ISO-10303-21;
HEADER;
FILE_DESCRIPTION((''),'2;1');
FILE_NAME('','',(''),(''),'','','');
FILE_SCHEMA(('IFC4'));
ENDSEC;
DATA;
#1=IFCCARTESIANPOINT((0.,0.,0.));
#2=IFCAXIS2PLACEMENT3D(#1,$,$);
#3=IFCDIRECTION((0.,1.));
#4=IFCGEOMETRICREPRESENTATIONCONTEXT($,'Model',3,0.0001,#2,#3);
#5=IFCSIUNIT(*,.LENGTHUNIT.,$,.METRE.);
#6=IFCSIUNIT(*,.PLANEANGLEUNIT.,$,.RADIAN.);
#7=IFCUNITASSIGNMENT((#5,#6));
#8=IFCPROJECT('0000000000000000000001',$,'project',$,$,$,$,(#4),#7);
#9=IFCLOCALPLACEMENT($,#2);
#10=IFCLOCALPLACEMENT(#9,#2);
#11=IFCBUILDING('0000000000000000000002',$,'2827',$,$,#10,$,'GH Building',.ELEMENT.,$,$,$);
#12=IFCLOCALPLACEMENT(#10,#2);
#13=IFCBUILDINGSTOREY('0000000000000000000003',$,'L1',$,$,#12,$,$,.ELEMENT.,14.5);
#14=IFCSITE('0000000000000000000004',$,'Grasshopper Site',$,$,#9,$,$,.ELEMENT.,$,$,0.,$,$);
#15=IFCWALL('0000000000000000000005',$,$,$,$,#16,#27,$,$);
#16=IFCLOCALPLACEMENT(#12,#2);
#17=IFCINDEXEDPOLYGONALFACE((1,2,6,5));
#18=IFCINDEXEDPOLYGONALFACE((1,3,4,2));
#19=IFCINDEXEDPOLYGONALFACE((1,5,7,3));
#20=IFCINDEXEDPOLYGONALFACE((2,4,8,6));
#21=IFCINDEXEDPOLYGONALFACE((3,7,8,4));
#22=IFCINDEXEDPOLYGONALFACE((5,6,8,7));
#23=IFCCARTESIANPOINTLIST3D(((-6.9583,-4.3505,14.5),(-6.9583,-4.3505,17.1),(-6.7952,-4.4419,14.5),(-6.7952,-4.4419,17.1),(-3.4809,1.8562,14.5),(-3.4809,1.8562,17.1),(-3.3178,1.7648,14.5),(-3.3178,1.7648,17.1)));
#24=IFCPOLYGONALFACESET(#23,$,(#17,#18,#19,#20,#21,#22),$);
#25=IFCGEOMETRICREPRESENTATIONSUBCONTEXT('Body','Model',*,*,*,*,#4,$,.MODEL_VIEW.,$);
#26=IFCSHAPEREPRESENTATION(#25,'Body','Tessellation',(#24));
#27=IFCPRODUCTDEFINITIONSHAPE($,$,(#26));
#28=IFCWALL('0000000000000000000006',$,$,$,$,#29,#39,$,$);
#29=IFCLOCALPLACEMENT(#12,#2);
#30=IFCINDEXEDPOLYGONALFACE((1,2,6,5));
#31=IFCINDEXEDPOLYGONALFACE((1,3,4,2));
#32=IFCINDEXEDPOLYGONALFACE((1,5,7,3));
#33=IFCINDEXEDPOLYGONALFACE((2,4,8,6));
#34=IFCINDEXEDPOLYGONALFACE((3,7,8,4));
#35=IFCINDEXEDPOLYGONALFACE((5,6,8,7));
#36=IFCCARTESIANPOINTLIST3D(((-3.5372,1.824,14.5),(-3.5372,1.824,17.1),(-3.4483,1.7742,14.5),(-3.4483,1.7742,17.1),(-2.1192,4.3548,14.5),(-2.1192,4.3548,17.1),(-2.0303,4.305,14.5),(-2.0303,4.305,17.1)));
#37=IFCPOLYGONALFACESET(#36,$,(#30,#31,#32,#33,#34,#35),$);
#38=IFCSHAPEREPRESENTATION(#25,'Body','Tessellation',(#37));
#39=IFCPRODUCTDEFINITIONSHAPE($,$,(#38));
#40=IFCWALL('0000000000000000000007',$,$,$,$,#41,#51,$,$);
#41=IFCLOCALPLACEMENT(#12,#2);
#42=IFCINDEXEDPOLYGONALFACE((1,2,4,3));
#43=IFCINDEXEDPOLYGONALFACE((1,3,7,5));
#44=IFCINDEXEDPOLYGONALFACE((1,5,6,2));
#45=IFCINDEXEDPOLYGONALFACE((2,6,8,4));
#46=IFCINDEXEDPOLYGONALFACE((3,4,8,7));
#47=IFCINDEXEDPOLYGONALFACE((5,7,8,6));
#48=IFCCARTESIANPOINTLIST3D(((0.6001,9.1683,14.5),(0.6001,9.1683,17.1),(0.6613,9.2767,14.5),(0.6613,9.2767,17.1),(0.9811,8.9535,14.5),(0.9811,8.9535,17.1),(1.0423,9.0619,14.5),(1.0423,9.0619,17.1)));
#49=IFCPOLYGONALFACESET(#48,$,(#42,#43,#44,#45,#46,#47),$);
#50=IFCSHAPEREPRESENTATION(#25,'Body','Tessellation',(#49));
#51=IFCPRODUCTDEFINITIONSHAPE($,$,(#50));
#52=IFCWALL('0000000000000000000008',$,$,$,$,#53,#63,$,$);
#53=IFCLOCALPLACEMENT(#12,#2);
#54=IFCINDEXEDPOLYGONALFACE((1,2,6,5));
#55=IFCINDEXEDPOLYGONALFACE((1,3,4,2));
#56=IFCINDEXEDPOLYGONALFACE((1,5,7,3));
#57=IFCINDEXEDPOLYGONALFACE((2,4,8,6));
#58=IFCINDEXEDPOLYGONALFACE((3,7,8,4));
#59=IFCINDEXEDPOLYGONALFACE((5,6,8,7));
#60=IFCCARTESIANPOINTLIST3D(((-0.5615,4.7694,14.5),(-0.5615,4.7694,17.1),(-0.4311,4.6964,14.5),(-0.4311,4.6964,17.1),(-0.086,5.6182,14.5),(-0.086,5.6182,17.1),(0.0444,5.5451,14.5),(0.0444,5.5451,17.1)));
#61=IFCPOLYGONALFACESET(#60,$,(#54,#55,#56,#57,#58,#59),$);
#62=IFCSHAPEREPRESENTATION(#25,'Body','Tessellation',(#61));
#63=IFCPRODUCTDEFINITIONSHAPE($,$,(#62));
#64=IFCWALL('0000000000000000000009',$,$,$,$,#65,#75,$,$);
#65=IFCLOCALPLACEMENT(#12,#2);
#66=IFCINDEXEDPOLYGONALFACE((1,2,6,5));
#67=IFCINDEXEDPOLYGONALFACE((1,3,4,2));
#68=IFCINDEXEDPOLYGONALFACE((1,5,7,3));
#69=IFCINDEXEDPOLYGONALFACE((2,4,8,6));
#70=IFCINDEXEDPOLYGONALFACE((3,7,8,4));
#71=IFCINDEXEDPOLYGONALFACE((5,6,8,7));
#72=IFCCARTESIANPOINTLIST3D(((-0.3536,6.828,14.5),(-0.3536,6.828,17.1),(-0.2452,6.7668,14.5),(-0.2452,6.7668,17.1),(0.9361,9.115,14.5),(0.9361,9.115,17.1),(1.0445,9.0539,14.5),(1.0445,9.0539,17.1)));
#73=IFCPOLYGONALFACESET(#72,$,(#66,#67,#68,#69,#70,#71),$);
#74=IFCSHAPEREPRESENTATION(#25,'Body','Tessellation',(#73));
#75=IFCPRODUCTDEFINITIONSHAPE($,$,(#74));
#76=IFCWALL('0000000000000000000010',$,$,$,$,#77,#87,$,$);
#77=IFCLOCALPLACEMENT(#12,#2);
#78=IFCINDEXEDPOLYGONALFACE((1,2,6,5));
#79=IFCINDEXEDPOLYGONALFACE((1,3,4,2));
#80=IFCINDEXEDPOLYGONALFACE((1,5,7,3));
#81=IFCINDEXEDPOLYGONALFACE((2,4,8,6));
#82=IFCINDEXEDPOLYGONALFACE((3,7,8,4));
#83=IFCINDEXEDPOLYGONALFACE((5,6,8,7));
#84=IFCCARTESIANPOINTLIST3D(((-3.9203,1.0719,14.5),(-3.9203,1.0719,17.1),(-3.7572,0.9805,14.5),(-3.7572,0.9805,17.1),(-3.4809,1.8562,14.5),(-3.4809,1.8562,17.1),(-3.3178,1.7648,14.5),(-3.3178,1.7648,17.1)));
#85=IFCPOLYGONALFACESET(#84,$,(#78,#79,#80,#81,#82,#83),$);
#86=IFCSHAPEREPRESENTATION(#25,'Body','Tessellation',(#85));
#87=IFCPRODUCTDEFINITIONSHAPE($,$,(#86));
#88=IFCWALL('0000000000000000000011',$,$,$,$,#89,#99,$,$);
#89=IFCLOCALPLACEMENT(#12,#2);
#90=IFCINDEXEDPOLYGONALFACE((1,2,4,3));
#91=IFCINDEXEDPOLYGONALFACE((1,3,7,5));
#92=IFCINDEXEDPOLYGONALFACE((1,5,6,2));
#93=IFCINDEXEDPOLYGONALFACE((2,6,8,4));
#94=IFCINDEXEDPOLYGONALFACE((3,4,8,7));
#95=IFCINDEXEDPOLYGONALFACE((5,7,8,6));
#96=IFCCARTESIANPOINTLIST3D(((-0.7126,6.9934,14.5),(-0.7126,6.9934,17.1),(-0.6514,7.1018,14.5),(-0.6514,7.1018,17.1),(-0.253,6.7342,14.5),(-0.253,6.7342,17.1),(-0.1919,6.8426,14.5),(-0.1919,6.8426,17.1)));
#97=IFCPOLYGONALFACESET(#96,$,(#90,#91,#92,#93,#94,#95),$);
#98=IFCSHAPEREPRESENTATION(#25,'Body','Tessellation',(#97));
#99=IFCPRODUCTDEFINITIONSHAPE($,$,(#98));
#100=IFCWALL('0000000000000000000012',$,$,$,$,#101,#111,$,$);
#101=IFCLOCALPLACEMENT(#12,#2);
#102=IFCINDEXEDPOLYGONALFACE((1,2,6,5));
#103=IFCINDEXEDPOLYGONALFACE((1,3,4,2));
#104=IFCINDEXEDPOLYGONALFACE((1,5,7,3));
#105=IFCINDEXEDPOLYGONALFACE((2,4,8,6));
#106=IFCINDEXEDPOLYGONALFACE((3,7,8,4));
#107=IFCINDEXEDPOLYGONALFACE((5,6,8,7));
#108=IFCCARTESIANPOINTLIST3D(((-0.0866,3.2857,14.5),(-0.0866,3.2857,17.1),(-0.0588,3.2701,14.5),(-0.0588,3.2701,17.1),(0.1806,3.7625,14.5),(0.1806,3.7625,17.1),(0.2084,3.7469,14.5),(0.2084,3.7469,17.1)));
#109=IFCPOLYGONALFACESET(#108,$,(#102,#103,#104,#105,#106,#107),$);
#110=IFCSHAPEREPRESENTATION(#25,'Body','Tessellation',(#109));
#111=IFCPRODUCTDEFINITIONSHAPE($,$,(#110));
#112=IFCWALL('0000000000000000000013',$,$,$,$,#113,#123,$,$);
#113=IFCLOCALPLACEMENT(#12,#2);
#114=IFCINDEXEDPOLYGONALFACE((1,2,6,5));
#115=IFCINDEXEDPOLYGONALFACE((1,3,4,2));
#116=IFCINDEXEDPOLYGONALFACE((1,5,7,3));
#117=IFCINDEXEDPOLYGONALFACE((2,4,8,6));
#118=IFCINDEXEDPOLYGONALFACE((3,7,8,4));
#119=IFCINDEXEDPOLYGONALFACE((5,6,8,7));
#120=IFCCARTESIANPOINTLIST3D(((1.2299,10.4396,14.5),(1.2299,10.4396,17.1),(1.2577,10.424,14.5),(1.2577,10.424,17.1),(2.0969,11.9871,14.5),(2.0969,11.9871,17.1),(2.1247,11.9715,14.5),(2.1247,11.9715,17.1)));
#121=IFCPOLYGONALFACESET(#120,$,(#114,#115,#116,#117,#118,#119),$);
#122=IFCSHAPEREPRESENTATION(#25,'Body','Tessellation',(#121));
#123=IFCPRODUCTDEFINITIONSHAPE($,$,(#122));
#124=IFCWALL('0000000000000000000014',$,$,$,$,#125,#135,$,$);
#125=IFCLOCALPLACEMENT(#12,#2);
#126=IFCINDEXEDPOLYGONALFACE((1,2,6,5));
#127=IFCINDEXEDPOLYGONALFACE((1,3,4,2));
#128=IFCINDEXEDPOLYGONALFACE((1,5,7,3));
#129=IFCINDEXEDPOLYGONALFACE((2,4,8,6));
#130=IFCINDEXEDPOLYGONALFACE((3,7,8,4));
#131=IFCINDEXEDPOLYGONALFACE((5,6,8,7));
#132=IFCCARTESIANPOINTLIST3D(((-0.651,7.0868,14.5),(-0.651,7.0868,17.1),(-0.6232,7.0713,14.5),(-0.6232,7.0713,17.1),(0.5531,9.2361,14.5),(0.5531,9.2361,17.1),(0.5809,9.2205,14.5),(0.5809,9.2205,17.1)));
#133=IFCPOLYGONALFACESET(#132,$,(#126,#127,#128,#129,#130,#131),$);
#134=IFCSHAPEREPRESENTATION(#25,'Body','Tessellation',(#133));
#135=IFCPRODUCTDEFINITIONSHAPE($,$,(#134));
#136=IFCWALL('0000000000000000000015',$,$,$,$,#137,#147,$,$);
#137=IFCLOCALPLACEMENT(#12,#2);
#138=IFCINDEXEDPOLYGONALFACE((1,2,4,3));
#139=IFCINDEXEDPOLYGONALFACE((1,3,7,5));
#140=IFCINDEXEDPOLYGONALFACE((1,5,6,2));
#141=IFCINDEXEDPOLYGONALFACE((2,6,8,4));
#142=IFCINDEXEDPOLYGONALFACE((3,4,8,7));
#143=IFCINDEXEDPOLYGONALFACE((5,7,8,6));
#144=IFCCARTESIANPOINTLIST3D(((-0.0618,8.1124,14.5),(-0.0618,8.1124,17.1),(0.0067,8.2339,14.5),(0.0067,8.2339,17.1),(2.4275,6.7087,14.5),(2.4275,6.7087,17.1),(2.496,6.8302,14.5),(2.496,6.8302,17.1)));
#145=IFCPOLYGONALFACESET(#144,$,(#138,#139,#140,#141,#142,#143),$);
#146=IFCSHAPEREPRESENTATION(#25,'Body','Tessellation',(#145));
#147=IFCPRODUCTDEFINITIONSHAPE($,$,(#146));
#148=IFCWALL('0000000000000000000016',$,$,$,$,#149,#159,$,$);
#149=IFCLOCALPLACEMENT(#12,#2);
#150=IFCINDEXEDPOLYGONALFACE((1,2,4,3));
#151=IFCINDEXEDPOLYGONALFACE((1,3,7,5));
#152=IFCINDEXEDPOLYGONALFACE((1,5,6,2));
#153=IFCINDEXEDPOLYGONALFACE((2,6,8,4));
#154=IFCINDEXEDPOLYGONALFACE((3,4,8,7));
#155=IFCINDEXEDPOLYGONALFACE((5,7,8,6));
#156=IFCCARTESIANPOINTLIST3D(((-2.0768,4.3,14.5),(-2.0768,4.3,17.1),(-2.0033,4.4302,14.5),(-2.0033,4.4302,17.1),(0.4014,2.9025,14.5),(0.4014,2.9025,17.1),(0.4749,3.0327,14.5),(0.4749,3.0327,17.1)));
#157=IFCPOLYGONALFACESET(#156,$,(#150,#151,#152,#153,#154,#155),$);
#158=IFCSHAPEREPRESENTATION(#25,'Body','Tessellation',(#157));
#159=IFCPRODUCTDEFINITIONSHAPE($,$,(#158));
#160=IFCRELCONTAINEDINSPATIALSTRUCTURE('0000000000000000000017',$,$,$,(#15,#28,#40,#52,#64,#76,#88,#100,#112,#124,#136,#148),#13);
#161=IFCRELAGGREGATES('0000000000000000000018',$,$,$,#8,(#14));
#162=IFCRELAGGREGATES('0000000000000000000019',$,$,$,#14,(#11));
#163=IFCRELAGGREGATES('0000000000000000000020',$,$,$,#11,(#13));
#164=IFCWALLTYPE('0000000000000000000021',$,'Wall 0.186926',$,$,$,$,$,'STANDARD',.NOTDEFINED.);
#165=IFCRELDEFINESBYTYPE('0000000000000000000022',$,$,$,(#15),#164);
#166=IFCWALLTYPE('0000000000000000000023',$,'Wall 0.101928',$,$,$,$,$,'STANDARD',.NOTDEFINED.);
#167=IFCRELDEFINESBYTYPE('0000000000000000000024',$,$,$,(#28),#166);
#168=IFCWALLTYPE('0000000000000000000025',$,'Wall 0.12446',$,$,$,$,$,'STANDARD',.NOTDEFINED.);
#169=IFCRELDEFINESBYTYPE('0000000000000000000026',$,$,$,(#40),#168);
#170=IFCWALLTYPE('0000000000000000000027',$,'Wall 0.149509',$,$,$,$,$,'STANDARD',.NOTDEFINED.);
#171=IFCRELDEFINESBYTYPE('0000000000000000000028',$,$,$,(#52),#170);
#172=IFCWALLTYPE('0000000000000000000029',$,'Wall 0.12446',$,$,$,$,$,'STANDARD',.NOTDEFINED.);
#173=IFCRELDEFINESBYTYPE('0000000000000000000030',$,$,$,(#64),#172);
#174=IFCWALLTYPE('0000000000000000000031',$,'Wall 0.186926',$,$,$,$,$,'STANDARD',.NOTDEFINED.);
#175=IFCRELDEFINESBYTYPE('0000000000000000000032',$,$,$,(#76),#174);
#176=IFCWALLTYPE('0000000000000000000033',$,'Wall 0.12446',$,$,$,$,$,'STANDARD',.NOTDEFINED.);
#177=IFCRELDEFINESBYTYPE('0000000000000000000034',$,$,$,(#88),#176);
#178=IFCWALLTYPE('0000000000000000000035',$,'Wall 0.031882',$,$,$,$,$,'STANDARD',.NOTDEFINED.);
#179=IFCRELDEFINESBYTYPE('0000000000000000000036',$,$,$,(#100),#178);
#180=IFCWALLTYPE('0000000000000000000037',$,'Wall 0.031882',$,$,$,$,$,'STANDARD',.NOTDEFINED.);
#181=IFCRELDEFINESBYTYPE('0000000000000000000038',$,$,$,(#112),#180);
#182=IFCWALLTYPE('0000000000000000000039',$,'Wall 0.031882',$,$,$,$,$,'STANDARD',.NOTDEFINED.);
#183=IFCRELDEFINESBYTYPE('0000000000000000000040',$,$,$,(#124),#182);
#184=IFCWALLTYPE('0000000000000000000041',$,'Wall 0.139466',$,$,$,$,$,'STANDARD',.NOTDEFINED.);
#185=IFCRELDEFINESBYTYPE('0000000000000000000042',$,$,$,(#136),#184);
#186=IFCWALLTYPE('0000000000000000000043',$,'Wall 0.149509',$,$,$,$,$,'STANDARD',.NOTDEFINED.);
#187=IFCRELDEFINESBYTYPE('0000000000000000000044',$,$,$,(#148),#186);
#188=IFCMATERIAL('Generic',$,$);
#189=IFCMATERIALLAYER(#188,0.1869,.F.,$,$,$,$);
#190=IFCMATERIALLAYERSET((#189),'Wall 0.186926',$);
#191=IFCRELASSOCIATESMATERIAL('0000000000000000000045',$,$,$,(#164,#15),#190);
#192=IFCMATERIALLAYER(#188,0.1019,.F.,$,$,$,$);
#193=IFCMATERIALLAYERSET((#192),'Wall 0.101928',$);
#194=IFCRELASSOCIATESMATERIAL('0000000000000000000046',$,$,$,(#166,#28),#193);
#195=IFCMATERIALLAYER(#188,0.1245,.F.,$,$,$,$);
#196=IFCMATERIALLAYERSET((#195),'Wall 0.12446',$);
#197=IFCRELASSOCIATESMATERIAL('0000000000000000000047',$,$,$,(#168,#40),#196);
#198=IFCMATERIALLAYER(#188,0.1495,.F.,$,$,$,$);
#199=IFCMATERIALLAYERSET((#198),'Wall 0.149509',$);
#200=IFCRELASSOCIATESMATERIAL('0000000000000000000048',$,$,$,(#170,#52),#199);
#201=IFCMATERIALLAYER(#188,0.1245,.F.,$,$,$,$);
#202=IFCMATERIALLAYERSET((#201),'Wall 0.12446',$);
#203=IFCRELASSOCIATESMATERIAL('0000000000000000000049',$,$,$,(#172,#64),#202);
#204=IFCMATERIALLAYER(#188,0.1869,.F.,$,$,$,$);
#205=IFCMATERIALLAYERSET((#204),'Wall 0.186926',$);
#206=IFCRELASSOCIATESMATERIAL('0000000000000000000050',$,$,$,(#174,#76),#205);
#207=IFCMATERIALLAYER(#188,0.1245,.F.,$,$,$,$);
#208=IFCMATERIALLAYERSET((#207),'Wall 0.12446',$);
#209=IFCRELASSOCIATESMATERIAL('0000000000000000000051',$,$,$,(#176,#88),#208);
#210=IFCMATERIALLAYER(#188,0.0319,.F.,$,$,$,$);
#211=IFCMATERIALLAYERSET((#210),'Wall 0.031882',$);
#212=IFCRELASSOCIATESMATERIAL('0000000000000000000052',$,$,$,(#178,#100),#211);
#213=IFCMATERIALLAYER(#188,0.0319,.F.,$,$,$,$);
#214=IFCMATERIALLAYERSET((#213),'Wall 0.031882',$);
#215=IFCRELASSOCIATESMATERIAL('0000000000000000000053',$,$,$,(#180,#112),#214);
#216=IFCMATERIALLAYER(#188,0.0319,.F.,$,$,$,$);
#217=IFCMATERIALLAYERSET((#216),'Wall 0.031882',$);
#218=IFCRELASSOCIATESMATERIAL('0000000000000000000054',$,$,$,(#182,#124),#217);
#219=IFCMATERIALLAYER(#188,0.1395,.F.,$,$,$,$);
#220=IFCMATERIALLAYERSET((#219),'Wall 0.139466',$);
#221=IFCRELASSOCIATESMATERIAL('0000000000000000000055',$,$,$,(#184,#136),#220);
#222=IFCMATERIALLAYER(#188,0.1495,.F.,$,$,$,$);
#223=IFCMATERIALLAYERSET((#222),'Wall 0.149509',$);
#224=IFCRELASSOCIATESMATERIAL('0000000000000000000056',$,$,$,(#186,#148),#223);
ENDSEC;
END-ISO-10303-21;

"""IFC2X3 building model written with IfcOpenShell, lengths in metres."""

from ifc_helpers import new_model, si_unit, direction, frame, frame_2d, origin, place, context, subcontext, project, spatial, rectangle, extrude, material, layer, layer_set, layer_usage, type_object, element, save


model = new_model("IFC2X3")

# Units and contexts
model_context = context("Model", 3, precision=0.0001, world=origin(), true_north=direction((0.0, 1.0)))
body_context = subcontext(model_context, "Body", "Model", "MODEL_VIEW")
ifc_project = project(units=[si_unit("LENGTHUNIT", "METRE"), si_unit("PLANEANGLEUNIT", "RADIAN")], contexts=[model_context])

# Site, building, storey
site_placement = place(None, origin())
site = spatial("IfcSite", under=ifc_project, at=site_placement, Name="Grasshopper Site", CompositionType="ELEMENT", RefElevation=0.0)
building_placement = place(site_placement, origin())
building = spatial("IfcBuilding", under=site, at=building_placement, Name="2827", LongName="GH Building", CompositionType="ELEMENT")
storey_placement = place(building_placement, origin())
storey = spatial("IfcBuildingStorey", under=building, at=storey_placement, Name="L1", CompositionType="ELEMENT", Elevation=14.5)

# Walls
ifc_material = material(Name="Generic")
ifc_layer_1 = layer(ifc_material, 0.1869, ventilated=False)
ifc_layer_set_1 = layer_set([ifc_layer_1], Name="Wall 0.186926")
ifc_layer_usage_1 = layer_usage(ifc_layer_set_1, "AXIS2", "NEGATIVE", 0.0935)
wall_type_1 = type_object("IfcWallType", Name="Wall 0.186926", ElementType="STANDARD", PredefinedType="NOTDEFINED", material=ifc_layer_set_1)
wall_1_placement = place(storey_placement, frame((-3.3993, 1.8105, 14.5), z_axis=(0.0, 0.0, 1.0), x_axis=(-0.488782, -0.872406, 0.0)))
element("IfcWall", 1, at=wall_1_placement, inside=storey, type_object=wall_type_1, material=ifc_layer_usage_1, context=body_context, shape_type="SweptSolid", body=[
    extrude(rectangle(XDim=7.1144, YDim=0.1869, at=frame_2d((3.5572, 0.0))), origin(), (0.0, 0.0, 1.0), 2.6),
])
ifc_layer_2 = layer(ifc_material, 0.1019, ventilated=False)
ifc_layer_set_2 = layer_set([ifc_layer_2], Name="Wall 0.101928")
ifc_layer_usage_2 = layer_usage(ifc_layer_set_2, "AXIS2", "NEGATIVE", 0.051)
wall_type_2 = type_object("IfcWallType", Name="Wall 0.101928", ElementType="STANDARD", PredefinedType="NOTDEFINED", material=ifc_layer_set_2)
wall_2_placement = place(storey_placement, frame((-3.4927, 1.7991, 14.5), z_axis=(0.0, 0.0, 1.0), x_axis=(0.488782, 0.872406, 0.0)))
element("IfcWall", 2, at=wall_2_placement, inside=storey, type_object=wall_type_2, material=ifc_layer_usage_2, context=body_context, shape_type="SweptSolid", body=[
    extrude(rectangle(XDim=2.901, YDim=0.1019, at=frame_2d((1.4505, 0.0))), origin(), (0.0, 0.0, 1.0), 2.6),
])
ifc_layer_3 = layer(ifc_material, 0.1245, ventilated=False)
ifc_layer_set_3 = layer_set([ifc_layer_3], Name="Wall 0.12446")
ifc_layer_usage_3 = layer_usage(ifc_layer_set_3, "AXIS2", "NEGATIVE", 0.0622)
wall_type_3 = type_object("IfcWallType", Name="Wall 0.12446", ElementType="STANDARD", PredefinedType="NOTDEFINED", material=ifc_layer_set_3)
wall_3_placement = place(storey_placement, frame((1.0117, 9.0077, 14.5), z_axis=(0.0, 0.0, 1.0), x_axis=(-0.871054, 0.491187, 0.0)))
element("IfcWall", 3, at=wall_3_placement, inside=storey, type_object=wall_type_3, material=ifc_layer_usage_3, context=body_context, shape_type="SweptSolid", body=[
    extrude(rectangle(XDim=0.4374, YDim=0.1245, at=frame_2d((0.2187, 0.0))), origin(), (0.0, 0.0, 1.0), 2.6),
])

# Walls
ifc_layer_4 = layer(ifc_material, 0.1495, ventilated=False)
ifc_layer_set_4 = layer_set([ifc_layer_4], Name="Wall 0.149509")
ifc_layer_usage_4 = layer_usage(ifc_layer_set_4, "AXIS2", "NEGATIVE", 0.0748)
wall_type_4 = type_object("IfcWallType", Name="Wall 0.149509", ElementType="STANDARD", PredefinedType="NOTDEFINED", material=ifc_layer_set_4)
wall_4_placement = place(storey_placement, frame((-0.4963, 4.7329, 14.5), z_axis=(0.0, 0.0, 1.0), x_axis=(0.488782, 0.872406, 0.0)))
element("IfcWall", 4, at=wall_4_placement, inside=storey, type_object=wall_type_4, material=ifc_layer_usage_4, context=body_context, shape_type="SweptSolid", body=[
    extrude(rectangle(XDim=0.9729, YDim=0.1495, at=frame_2d((0.4865, 0.0))), origin(), (0.0, 0.0, 1.0), 2.6),
])
ifc_layer_5 = layer(ifc_material, 0.1245, ventilated=False)
ifc_layer_set_5 = layer_set([ifc_layer_5], Name="Wall 0.12446")
ifc_layer_usage_5 = layer_usage(ifc_layer_set_5, "AXIS2", "NEGATIVE", 0.0622)
wall_type_5 = type_object("IfcWallType", Name="Wall 0.12446", ElementType="STANDARD", PredefinedType="NOTDEFINED", material=ifc_layer_set_5)
wall_5_placement = place(storey_placement, frame((0.9903, 9.0845, 14.5), z_axis=(0.0, 0.0, 1.0), x_axis=(-0.491187, -0.871054, 0.0)))
element("IfcWall", 5, at=wall_5_placement, inside=storey, type_object=wall_type_5, material=ifc_layer_usage_5, context=body_context, shape_type="SweptSolid", body=[
    extrude(rectangle(XDim=2.6256, YDim=0.1245, at=frame_2d((1.3128, 0.0))), origin(), (0.0, 0.0, 1.0), 2.6),
])
ifc_layer_6 = layer(ifc_material, 0.1869, ventilated=False)
ifc_layer_set_6 = layer_set([ifc_layer_6], Name="Wall 0.186926")
ifc_layer_usage_6 = layer_usage(ifc_layer_set_6, "AXIS2", "NEGATIVE", 0.0935)
wall_type_6 = type_object("IfcWallType", Name="Wall 0.186926", ElementType="STANDARD", PredefinedType="NOTDEFINED", material=ifc_layer_set_6)
wall_6_placement = place(storey_placement, frame((-3.3993, 1.8105, 14.5), z_axis=(0.0, 0.0, 1.0), x_axis=(-0.488782, -0.872406, 0.0)))
element("IfcWall", 6, at=wall_6_placement, inside=storey, type_object=wall_type_6, material=ifc_layer_usage_6, context=body_context, shape_type="SweptSolid", body=[
    extrude(rectangle(XDim=0.899, YDim=0.1869, at=frame_2d((0.4495, 0.0))), origin(), (0.0, 0.0, 1.0), 2.6),
])

# Wall
ifc_layer_7 = layer(ifc_material, 0.1245, ventilated=False)
ifc_layer_set_7 = layer_set([ifc_layer_7], Name="Wall 0.12446")
ifc_layer_usage_7 = layer_usage(ifc_layer_set_7, "AXIS2", "NEGATIVE", 0.0622)
wall_type_7 = type_object("IfcWallType", Name="Wall 0.12446", ElementType="STANDARD", PredefinedType="NOTDEFINED", material=ifc_layer_set_7)
wall_7_placement = place(storey_placement, frame((-0.2225, 6.7884, 14.5), z_axis=(0.0, 0.0, 1.0), x_axis=(-0.871054, 0.491187, 0.0)))
element("IfcWall", 7, at=wall_7_placement, inside=storey, type_object=wall_type_7, material=ifc_layer_usage_7, context=body_context, shape_type="SweptSolid", body=[
    extrude(rectangle(XDim=0.5276, YDim=0.1245, at=frame_2d((0.2638, 0.0))), origin(), (0.0, 0.0, 1.0), 2.6),
])

# Walls
ifc_layer_8 = layer(ifc_material, 0.0319, ventilated=False)
ifc_layer_set_8 = layer_set([ifc_layer_8], Name="Wall 0.031882")
ifc_layer_usage_8 = layer_usage(ifc_layer_set_8, "AXIS2", "NEGATIVE", 0.0159)
wall_type_8 = type_object("IfcWallType", Name="Wall 0.031882", ElementType="STANDARD", PredefinedType="NOTDEFINED", material=ifc_layer_set_8)
wall_8_placement = place(storey_placement, frame((0.1945, 3.7547, 14.5), z_axis=(0.0, 0.0, 1.0), x_axis=(-0.488782, -0.872406, 0.0)))
element("IfcWall", 8, at=wall_8_placement, inside=storey, type_object=wall_type_8, material=ifc_layer_usage_8, context=body_context, shape_type="SweptSolid", body=[
    extrude(rectangle(XDim=0.5465, YDim=0.0319, at=frame_2d((0.2733, 0.0))), origin(), (0.0, 0.0, 1.0), 2.6),
])
ifc_layer_9 = layer(ifc_material, 0.0319, ventilated=False)
ifc_layer_set_9 = layer_set([ifc_layer_9], Name="Wall 0.031882")
ifc_layer_usage_9 = layer_usage(ifc_layer_set_9, "AXIS2", "NEGATIVE", 0.0159)
wall_type_9 = type_object("IfcWallType", Name="Wall 0.031882", ElementType="STANDARD", PredefinedType="NOTDEFINED", material=ifc_layer_set_9)
wall_9_placement = place(storey_placement, frame((1.2438, 10.4318, 14.5), z_axis=(0.0, 0.0, 1.0), x_axis=(0.488782, 0.872406, 0.0)))
element("IfcWall", 9, at=wall_9_placement, inside=storey, type_object=wall_type_9, material=ifc_layer_usage_9, context=body_context, shape_type="SweptSolid", body=[
    extrude(rectangle(XDim=1.7738, YDim=0.0319, at=frame_2d((0.8869, 0.0))), origin(), (0.0, 0.0, 1.0), 2.6),
])

# Walls
ifc_layer_10 = layer(ifc_material, 0.0319, ventilated=False)
ifc_layer_set_10 = layer_set([ifc_layer_10], Name="Wall 0.031882")
ifc_layer_usage_10 = layer_usage(ifc_layer_set_10, "AXIS2", "NEGATIVE", 0.0159)
wall_type_10 = type_object("IfcWallType", Name="Wall 0.031882", ElementType="STANDARD", PredefinedType="NOTDEFINED", material=ifc_layer_set_10)
wall_10_placement = place(storey_placement, frame((0.567, 9.2283, 14.5), z_axis=(0.0, 0.0, 1.0), x_axis=(-0.488782, -0.872406, 0.0)))
element("IfcWall", 10, at=wall_10_placement, inside=storey, type_object=wall_type_10, material=ifc_layer_usage_10, context=body_context, shape_type="SweptSolid", body=[
    extrude(rectangle(XDim=2.4636, YDim=0.0319, at=frame_2d((1.2318, 0.0))), origin(), (0.0, 0.0, 1.0), 2.6),
])
ifc_layer_11 = layer(ifc_material, 0.1395, ventilated=False)
ifc_layer_set_11 = layer_set([ifc_layer_11], Name="Wall 0.139466")
ifc_layer_usage_11 = layer_usage(ifc_layer_set_11, "AXIS2", "NEGATIVE", 0.0697)
wall_type_11 = type_object("IfcWallType", Name="Wall 0.139466", ElementType="STANDARD", PredefinedType="NOTDEFINED", material=ifc_layer_set_11)
wall_11_placement = place(storey_placement, frame((-0.0276, 8.1732, 14.5), z_axis=(0.0, 0.0, 1.0), x_axis=(0.871054, -0.491187, 0.0)))
element("IfcWall", 11, at=wall_11_placement, inside=storey, type_object=wall_type_11, material=ifc_layer_usage_11, context=body_context, shape_type="SweptSolid", body=[
    extrude(rectangle(XDim=2.8579, YDim=0.1395, at=frame_2d((1.4289, 0.0))), origin(), (0.0, 0.0, 1.0), 2.6),
])
ifc_layer_12 = layer(ifc_material, 0.1495, ventilated=False)
ifc_layer_set_12 = layer_set([ifc_layer_12], Name="Wall 0.149509")
ifc_layer_usage_12 = layer_usage(ifc_layer_set_12, "AXIS2", "NEGATIVE", 0.0748)
wall_type_12 = type_object("IfcWallType", Name="Wall 0.149509", ElementType="STANDARD", PredefinedType="NOTDEFINED", material=ifc_layer_set_12)
wall_12_placement = place(storey_placement, frame((0.4382, 2.9676, 14.5), z_axis=(0.0, 0.0, 1.0), x_axis=(-0.871054, 0.491187, 0.0)))
element("IfcWall", 12, at=wall_12_placement, inside=storey, type_object=wall_type_12, material=ifc_layer_usage_12, context=body_context, shape_type="SweptSolid", body=[
    extrude(rectangle(XDim=2.8451, YDim=0.1495, at=frame_2d((1.4225, 0.0))), origin(), (0.0, 0.0, 1.0), 2.6),
])

save(model, "model.ifc")
